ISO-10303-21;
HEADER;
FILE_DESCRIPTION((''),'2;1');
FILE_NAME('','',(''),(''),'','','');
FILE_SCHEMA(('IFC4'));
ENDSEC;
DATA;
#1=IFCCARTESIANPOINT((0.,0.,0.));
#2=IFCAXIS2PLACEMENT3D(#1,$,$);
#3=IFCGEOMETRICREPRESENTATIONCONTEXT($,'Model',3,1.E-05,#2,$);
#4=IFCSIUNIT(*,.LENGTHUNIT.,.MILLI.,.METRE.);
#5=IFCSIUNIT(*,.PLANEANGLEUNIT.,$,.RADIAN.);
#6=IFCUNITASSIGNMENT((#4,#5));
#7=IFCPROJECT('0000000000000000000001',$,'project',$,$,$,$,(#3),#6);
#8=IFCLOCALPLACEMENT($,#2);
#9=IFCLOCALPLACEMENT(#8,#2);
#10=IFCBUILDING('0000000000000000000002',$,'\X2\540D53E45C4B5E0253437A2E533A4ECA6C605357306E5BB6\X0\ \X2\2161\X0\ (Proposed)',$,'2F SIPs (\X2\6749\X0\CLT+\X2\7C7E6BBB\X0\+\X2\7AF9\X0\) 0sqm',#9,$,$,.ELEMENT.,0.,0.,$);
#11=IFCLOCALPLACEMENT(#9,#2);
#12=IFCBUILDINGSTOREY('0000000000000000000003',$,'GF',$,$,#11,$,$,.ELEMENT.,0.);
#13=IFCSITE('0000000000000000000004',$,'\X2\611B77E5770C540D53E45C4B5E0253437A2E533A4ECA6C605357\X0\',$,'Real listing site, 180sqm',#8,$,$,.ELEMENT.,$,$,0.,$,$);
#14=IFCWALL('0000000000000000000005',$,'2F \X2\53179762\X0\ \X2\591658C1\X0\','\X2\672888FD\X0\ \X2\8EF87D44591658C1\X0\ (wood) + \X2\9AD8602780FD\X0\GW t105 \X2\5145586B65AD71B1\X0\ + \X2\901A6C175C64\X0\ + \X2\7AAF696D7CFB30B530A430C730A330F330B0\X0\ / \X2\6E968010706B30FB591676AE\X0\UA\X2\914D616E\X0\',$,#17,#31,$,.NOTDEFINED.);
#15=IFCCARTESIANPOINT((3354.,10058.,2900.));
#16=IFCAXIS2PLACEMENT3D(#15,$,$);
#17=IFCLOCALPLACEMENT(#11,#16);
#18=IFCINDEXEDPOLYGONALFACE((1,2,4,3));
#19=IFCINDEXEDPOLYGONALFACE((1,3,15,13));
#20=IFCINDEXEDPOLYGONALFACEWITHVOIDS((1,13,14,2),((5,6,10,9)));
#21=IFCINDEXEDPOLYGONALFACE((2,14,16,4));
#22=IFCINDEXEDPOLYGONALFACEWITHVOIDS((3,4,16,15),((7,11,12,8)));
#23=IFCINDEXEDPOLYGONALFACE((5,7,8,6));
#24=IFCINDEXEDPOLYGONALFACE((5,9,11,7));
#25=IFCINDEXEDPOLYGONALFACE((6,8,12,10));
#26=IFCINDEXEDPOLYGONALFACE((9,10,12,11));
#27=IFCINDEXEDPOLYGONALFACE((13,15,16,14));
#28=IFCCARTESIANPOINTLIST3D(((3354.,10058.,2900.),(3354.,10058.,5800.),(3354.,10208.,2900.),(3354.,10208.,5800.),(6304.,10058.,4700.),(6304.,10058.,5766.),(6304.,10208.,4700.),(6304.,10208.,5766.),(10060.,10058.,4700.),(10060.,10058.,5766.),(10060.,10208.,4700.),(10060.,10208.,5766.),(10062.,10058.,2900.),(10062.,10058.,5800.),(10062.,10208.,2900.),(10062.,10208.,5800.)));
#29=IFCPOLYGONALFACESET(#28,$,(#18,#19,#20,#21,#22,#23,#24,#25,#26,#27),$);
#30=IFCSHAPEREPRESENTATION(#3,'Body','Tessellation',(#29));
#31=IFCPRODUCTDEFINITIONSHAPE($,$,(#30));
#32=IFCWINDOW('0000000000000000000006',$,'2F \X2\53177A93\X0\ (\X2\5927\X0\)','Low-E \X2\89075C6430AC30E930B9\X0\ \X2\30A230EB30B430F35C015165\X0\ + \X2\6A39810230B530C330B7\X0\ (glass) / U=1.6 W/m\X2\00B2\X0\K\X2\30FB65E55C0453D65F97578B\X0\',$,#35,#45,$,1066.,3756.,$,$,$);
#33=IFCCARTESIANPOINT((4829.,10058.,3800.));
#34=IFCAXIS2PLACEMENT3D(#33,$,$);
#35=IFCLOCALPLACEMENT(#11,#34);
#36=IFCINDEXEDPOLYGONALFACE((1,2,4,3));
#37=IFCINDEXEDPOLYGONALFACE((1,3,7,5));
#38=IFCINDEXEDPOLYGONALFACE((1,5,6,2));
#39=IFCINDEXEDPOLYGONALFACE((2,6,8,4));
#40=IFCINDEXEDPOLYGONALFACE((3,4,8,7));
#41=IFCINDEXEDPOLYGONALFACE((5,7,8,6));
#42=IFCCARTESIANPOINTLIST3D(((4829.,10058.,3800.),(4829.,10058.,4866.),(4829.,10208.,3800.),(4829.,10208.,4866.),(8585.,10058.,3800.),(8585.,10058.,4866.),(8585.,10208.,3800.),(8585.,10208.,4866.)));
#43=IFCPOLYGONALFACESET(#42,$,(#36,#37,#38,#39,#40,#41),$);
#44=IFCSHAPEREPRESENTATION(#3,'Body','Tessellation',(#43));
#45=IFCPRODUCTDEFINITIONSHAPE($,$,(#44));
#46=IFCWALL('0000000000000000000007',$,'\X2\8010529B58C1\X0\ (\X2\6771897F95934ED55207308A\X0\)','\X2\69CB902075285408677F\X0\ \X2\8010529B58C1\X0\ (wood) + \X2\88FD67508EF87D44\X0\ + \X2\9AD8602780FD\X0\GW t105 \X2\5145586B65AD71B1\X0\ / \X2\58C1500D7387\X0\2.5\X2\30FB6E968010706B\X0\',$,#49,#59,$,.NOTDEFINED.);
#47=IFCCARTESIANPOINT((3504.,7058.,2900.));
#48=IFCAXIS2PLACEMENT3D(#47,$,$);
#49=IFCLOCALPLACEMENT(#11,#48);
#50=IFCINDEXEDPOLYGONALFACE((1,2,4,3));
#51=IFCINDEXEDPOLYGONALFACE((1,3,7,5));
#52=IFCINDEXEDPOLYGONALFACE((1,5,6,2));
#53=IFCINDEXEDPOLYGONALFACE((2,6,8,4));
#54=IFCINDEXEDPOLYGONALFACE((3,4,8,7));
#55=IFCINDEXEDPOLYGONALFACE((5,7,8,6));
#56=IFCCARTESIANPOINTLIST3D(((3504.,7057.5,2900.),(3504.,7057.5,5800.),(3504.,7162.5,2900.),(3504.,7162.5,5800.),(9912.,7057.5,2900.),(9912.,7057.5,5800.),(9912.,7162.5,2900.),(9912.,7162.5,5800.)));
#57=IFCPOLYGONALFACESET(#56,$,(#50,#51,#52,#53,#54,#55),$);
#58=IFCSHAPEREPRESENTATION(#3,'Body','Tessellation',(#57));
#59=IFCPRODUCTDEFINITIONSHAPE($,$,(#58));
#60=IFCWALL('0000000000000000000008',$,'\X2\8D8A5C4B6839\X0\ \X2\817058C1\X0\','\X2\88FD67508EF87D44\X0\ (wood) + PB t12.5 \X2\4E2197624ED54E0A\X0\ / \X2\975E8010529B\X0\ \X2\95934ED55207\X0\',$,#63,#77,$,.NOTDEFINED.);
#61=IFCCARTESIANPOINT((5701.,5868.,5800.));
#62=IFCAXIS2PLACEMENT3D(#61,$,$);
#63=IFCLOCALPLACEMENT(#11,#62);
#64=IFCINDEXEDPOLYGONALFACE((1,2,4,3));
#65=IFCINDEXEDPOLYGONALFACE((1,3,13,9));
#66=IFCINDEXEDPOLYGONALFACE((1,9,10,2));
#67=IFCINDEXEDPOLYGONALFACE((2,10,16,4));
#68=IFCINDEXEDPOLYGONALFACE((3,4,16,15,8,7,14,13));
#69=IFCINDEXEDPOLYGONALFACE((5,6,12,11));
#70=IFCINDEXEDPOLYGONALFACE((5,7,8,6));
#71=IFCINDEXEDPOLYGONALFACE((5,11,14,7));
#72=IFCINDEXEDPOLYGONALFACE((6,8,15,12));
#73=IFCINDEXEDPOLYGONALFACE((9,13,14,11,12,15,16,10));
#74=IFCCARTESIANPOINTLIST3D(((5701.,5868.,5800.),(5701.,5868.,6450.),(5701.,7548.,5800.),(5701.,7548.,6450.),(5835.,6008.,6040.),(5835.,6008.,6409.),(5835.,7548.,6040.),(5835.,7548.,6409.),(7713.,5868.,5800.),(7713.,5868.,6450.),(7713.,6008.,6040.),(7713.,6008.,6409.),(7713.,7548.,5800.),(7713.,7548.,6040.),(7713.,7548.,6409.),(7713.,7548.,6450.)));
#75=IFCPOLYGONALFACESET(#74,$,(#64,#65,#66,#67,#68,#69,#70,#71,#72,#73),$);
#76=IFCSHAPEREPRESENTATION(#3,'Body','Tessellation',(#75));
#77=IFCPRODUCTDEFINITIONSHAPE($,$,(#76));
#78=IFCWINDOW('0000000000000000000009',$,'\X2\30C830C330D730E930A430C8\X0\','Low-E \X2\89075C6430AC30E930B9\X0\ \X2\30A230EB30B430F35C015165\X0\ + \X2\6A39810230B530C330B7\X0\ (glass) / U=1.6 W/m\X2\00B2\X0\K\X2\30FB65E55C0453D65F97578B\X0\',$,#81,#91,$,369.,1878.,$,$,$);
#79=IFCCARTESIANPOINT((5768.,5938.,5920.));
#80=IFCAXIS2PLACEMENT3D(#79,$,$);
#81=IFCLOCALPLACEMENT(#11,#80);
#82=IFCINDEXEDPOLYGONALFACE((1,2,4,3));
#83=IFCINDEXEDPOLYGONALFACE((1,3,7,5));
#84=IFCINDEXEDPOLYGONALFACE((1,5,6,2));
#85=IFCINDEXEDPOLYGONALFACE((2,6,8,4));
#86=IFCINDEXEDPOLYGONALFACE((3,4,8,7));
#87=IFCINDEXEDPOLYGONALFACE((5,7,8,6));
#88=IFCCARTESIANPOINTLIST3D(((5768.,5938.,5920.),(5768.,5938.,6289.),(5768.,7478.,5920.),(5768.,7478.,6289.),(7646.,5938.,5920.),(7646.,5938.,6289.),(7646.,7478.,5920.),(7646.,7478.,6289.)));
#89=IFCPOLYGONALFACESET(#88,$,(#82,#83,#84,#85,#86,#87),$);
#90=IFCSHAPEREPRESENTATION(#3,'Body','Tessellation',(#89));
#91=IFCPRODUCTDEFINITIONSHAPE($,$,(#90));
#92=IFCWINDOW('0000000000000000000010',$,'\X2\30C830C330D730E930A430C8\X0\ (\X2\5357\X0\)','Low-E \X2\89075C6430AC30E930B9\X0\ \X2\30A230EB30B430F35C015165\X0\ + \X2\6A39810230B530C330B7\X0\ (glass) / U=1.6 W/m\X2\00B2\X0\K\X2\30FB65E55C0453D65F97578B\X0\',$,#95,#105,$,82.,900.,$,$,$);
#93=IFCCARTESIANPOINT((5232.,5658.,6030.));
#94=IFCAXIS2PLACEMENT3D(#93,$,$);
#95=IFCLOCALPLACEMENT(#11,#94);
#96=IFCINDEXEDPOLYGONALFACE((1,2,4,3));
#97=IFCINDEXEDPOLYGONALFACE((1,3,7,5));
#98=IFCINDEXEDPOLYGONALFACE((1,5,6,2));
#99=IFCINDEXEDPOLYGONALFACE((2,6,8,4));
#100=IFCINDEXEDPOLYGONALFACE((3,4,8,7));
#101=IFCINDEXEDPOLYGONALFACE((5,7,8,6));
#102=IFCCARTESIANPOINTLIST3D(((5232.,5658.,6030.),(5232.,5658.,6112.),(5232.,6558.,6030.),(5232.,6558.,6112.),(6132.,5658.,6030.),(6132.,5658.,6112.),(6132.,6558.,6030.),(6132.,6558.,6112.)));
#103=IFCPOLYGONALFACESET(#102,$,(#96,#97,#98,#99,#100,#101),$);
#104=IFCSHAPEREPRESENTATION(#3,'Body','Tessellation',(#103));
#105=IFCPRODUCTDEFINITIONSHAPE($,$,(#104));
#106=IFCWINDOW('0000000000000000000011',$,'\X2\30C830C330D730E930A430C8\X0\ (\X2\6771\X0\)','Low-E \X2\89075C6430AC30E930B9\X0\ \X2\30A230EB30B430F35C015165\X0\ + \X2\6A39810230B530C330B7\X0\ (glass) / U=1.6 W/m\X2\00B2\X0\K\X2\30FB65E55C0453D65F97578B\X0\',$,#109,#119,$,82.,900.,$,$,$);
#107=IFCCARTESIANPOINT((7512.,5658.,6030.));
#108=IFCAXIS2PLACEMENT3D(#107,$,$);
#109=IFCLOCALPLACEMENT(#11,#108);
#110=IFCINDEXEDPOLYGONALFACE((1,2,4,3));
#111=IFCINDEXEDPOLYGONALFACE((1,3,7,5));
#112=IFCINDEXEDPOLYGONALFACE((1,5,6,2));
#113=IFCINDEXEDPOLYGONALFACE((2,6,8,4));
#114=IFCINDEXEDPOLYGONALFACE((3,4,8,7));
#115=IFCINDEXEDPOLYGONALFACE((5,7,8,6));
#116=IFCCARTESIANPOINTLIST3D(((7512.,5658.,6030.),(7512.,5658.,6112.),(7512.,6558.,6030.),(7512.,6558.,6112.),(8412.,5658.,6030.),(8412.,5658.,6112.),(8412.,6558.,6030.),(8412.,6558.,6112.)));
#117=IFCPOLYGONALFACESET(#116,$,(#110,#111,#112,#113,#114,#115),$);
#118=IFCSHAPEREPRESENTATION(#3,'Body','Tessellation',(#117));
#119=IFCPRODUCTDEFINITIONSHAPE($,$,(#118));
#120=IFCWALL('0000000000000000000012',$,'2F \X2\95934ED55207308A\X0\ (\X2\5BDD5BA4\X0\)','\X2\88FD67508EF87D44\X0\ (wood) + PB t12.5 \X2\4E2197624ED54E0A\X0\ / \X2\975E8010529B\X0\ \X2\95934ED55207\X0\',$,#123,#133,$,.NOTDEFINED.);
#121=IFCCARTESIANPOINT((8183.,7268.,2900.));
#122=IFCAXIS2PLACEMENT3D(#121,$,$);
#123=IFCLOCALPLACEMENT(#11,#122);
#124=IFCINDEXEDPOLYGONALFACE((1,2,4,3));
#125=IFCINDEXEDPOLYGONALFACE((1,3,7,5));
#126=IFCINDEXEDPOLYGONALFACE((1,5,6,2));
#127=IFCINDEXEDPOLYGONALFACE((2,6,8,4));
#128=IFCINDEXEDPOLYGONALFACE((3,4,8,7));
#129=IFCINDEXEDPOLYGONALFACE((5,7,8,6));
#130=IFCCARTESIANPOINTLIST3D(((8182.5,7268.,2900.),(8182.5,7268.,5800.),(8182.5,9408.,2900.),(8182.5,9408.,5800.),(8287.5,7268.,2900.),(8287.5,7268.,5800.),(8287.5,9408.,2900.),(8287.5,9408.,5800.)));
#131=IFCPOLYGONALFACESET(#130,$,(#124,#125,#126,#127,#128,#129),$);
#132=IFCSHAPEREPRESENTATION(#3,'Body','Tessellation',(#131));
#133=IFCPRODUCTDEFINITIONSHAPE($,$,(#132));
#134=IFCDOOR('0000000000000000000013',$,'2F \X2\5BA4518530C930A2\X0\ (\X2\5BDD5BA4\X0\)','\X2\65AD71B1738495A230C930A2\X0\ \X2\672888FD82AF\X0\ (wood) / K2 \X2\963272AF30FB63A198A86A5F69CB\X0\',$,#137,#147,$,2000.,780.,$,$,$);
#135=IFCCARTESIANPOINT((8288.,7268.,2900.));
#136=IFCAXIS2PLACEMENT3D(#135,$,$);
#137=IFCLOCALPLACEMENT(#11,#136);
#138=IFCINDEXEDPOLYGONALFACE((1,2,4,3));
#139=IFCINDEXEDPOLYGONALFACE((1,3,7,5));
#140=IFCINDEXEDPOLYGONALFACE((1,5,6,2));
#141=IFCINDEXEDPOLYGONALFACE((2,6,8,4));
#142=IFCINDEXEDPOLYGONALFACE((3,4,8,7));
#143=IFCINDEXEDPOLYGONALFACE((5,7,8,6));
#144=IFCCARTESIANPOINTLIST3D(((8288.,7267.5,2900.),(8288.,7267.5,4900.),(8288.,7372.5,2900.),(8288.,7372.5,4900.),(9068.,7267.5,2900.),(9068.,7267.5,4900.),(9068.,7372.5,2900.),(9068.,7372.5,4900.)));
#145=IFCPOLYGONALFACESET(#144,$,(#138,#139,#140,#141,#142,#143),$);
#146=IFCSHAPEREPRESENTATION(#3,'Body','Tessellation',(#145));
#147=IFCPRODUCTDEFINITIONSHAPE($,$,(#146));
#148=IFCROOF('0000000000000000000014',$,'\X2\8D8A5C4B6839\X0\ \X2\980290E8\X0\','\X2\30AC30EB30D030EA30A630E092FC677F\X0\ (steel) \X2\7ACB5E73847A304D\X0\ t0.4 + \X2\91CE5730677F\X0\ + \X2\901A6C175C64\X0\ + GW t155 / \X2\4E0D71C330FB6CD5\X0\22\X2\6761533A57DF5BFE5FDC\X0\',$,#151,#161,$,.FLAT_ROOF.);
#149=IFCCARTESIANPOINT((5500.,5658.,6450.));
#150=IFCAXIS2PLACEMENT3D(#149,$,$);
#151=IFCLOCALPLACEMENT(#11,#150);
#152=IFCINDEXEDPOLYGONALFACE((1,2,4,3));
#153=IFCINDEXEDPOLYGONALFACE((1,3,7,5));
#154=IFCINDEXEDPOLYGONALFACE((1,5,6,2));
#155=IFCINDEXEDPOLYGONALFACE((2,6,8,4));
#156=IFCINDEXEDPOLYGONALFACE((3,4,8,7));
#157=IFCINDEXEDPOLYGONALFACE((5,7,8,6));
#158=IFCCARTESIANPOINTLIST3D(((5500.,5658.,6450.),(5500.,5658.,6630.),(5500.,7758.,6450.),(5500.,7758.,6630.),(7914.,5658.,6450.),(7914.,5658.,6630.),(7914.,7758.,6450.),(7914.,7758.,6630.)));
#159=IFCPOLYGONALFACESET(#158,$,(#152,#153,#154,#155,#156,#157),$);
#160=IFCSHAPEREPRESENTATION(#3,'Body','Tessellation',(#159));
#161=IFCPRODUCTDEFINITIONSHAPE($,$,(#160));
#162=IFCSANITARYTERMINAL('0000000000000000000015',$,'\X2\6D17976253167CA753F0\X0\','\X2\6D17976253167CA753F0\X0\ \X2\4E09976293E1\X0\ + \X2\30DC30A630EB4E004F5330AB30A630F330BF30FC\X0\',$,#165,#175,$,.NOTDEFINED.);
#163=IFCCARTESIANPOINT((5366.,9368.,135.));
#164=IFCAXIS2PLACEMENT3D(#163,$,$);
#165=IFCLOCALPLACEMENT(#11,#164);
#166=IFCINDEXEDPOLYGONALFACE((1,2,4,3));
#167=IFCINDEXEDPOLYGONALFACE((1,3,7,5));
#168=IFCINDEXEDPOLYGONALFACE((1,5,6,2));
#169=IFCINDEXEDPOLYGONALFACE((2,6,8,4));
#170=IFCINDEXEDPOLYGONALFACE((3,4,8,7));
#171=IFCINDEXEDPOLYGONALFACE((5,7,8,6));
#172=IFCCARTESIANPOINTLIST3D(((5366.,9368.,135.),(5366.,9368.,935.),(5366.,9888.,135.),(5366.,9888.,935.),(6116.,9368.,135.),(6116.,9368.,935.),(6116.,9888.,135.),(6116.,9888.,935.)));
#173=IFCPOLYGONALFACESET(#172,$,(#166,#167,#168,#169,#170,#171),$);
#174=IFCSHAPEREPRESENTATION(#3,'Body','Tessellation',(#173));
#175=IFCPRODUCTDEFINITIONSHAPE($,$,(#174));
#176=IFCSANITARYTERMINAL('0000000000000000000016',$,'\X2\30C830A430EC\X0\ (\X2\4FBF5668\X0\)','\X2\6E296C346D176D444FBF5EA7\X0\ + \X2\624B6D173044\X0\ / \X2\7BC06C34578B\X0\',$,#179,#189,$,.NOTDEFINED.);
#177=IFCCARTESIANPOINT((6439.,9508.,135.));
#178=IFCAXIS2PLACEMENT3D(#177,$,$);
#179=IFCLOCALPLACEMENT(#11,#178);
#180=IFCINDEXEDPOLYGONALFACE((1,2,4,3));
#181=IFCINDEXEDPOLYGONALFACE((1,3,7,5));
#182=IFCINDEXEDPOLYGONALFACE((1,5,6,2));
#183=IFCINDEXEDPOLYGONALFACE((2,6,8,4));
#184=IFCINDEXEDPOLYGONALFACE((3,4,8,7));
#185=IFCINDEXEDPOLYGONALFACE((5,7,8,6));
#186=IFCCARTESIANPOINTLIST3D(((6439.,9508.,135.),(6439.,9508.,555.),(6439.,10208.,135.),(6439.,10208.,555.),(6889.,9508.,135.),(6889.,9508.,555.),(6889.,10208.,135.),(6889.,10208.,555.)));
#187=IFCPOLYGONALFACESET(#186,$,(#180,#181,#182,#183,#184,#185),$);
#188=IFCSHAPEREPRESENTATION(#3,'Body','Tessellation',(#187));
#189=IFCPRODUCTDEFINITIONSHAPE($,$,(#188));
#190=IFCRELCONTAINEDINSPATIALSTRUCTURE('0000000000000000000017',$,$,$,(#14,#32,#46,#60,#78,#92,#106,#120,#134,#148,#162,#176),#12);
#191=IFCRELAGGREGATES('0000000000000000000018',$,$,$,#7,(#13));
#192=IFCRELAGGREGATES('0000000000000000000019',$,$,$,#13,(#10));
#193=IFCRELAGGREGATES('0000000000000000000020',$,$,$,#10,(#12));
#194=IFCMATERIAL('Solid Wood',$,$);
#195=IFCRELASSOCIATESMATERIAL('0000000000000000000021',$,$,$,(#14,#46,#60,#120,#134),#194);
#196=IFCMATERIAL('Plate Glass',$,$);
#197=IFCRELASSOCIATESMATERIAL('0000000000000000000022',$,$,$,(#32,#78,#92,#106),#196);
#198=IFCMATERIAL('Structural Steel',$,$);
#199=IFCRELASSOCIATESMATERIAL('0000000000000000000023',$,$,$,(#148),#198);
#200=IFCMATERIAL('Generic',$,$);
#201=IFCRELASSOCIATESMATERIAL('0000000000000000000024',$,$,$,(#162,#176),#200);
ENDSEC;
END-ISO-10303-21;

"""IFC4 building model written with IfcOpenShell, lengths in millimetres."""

from ifc_helpers import new_model, si_unit, frame, frame_2d, origin, place, context, project, spatial, rectangle, extrude, material, element, fill, save


model = new_model("IFC4")

# Units and contexts
model_context = context("Model", 3, precision=1e-05, world=origin())
ifc_project = project(units=[si_unit("LENGTHUNIT", "METRE", prefix="MILLI"), si_unit("PLANEANGLEUNIT", "RADIAN")], contexts=[model_context])

# Site, building, storey
site_placement = place(None, origin())
site = spatial("IfcSite", under=ifc_project, at=site_placement, Name="愛知県名古屋市千種区今池南", ObjectType="Real listing site, 180sqm", CompositionType="ELEMENT", RefElevation=0.0)
building_placement = place(site_placement, origin())
building = spatial("IfcBuilding", under=site, at=building_placement, Name="名古屋市千種区今池南の家 Ⅱ (Proposed)", ObjectType="2F SIPs (杉CLT+籾殻+竹) 0sqm", CompositionType="ELEMENT", ElevationOfRefHeight=0.0, ElevationOfTerrain=0.0)
storey_placement = place(building_placement, origin())
storey = spatial("IfcBuildingStorey", under=building, at=storey_placement, Name="GF", CompositionType="ELEMENT", Elevation=0.0)

# Wall, opening, window
ifc_material_1 = material(Name="Solid Wood")
wall_1_placement = place(storey_placement, frame((3354.0, 10058.0, 2900.0)))
wall_1 = element("IfcWall", 1, at=wall_1_placement, inside=storey, material=ifc_material_1, Name="2F 北面 外壁", Description="木製 軸組外壁 (wood) + 高性能GW t105 充填断熱 + 通気層 + 窯業系サイディング / 準耐火・外皮UA配慮", PredefinedType="NOTDEFINED", context=model_context, shape_type="SweptSolid", body=[
    extrude(rectangle(XDim=6708.0, YDim=150.0, at=frame_2d((3354.0, 75.0))), frame((3354.0, 10058.0, 2900.0)), (0.0, 0.0, 1.0), 2900.0),
])
opening_1_placement = place(storey_placement, frame((4829.0, 10058.0, 3800.0)))
opening_1 = element("IfcOpeningElement", 2, at=opening_1_placement, cuts=wall_1, PredefinedType="NOTDEFINED", context=model_context, shape_type="SweptSolid", body=[
    extrude(rectangle(XDim=3756.0, YDim=150.0, at=frame_2d((1878.0, 75.0))), frame((4829.0, 10058.0, 3800.0)), (0.0, 0.0, 1.0), 1066.0),
])
ifc_material_2 = material(Name="Plate Glass")
window_1_placement = place(storey_placement, frame((4829.0, 10058.0, 3800.0)))
window_1 = element("IfcWindow", 3, at=window_1_placement, inside=storey, material=ifc_material_2, Name="2F 北窓 (大)", Description="Low-E 複層ガラス アルゴン封入 + 樹脂サッシ (glass) / U=1.6 W/m²K・日射取得型", OverallHeight=1066.0, OverallWidth=3756.0, context=model_context, shape_type="SweptSolid", body=[
    extrude(rectangle(XDim=3756.0, YDim=150.0, at=frame_2d((1878.0, 75.0))), frame((4829.0, 10058.0, 3800.0)), (0.0, 0.0, 1.0), 1066.0),
])
fill(opening_1, window_1)

# Wall
wall_2_placement = place(storey_placement, frame((3504.0, 7058.0, 2900.0)))
element("IfcWall", 4, at=wall_2_placement, inside=storey, material=ifc_material_1, Name="耐力壁 (東西間仕切り)", Description="構造用合板 耐力壁 (wood) + 製材軸組 + 高性能GW t105 充填断熱 / 壁倍率2.5・準耐火", PredefinedType="NOTDEFINED", context=model_context, shape_type="SweptSolid", body=[
    extrude(rectangle(XDim=6408.0, YDim=105.0, at=frame_2d((3204.0, 52.0))), frame((3504.0, 7058.0, 2900.0)), (0.0, 0.0, 1.0), 2900.0),
])

# Wall, openings, windows
wall_3_placement = place(storey_placement, frame((5701.0, 5868.0, 5800.0)))
wall_3 = element("IfcWall", 5, at=wall_3_placement, inside=storey, material=ifc_material_1, Name="越屋根 腰壁", Description="製材軸組 (wood) + PB t12.5 両面仕上 / 非耐力 間仕切", PredefinedType="NOTDEFINED", context=model_context, shape_type="SweptSolid", body=[
    extrude(rectangle(XDim=2012.0, YDim=1680.0, at=frame_2d((1006.0, 840.0))), frame((5701.0, 5868.0, 5800.0)), (0.0, 0.0, 1.0), 650.0),
])
opening_2_placement = place(storey_placement, frame((5768.0, 5938.0, 5920.0)))
opening_2 = element("IfcOpeningElement", 6, at=opening_2_placement, cuts=wall_3, PredefinedType="NOTDEFINED", context=model_context, shape_type="SweptSolid", body=[
    extrude(rectangle(XDim=1878.0, YDim=1540.0, at=frame_2d((939.0, 770.0))), frame((5768.0, 5938.0, 5920.0)), (0.0, 0.0, 1.0), 369.0),
])
opening_3_placement = place(storey_placement, frame((5232.0, 5658.0, 6030.0)))
opening_3 = element("IfcOpeningElement", 7, at=opening_3_placement, cuts=wall_3, PredefinedType="NOTDEFINED", context=model_context, shape_type="SweptSolid", body=[
    extrude(rectangle(XDim=900.0, YDim=900.0, at=frame_2d((450.0, 450.0))), frame((5232.0, 5658.0, 6030.0)), (0.0, 0.0, 1.0), 82.0),
])
opening_4_placement = place(storey_placement, frame((7512.0, 5658.0, 6030.0)))
opening_4 = element("IfcOpeningElement", 8, at=opening_4_placement, cuts=wall_3, PredefinedType="NOTDEFINED", context=model_context, shape_type="SweptSolid", body=[
    extrude(rectangle(XDim=900.0, YDim=900.0, at=frame_2d((450.0, 450.0))), frame((7512.0, 5658.0, 6030.0)), (0.0, 0.0, 1.0), 82.0),
])
window_2_placement = place(storey_placement, frame((5768.0, 5938.0, 5920.0)))
window_2 = element("IfcWindow", 9, at=window_2_placement, inside=storey, material=ifc_material_2, Name="トップライト", Description="Low-E 複層ガラス アルゴン封入 + 樹脂サッシ (glass) / U=1.6 W/m²K・日射取得型", OverallHeight=369.0, OverallWidth=1878.0, context=model_context, shape_type="SweptSolid", body=[
    extrude(rectangle(XDim=1878.0, YDim=1540.0, at=frame_2d((939.0, 770.0))), frame((5768.0, 5938.0, 5920.0)), (0.0, 0.0, 1.0), 369.0),
])
fill(opening_2, window_2)
window_3_placement = place(storey_placement, frame((5232.0, 5658.0, 6030.0)))
window_3 = element("IfcWindow", 10, at=window_3_placement, inside=storey, material=ifc_material_2, Name="トップライト (南)", Description="Low-E 複層ガラス アルゴン封入 + 樹脂サッシ (glass) / U=1.6 W/m²K・日射取得型", OverallHeight=82.0, OverallWidth=900.0, context=model_context, shape_type="SweptSolid", body=[
    extrude(rectangle(XDim=900.0, YDim=900.0, at=frame_2d((450.0, 450.0))), frame((5232.0, 5658.0, 6030.0)), (0.0, 0.0, 1.0), 82.0),
])
fill(opening_3, window_3)
window_4_placement = place(storey_placement, frame((7512.0, 5658.0, 6030.0)))
window_4 = element("IfcWindow", 11, at=window_4_placement, inside=storey, material=ifc_material_2, Name="トップライト (東)", Description="Low-E 複層ガラス アルゴン封入 + 樹脂サッシ (glass) / U=1.6 W/m²K・日射取得型", OverallHeight=82.0, OverallWidth=900.0, context=model_context, shape_type="SweptSolid", body=[
    extrude(rectangle(XDim=900.0, YDim=900.0, at=frame_2d((450.0, 450.0))), frame((7512.0, 5658.0, 6030.0)), (0.0, 0.0, 1.0), 82.0),
])
fill(opening_4, window_4)

# Wall
wall_4_placement = place(storey_placement, frame((8183.0, 7268.0, 2900.0)))
element("IfcWall", 12, at=wall_4_placement, inside=storey, material=ifc_material_1, Name="2F 間仕切り (寝室)", Description="製材軸組 (wood) + PB t12.5 両面仕上 / 非耐力 間仕切", PredefinedType="NOTDEFINED", context=model_context, shape_type="SweptSolid", body=[
    extrude(rectangle(XDim=105.0, YDim=2140.0, at=frame_2d((52.0, 1070.0))), frame((8183.0, 7268.0, 2900.0)), (0.0, 0.0, 1.0), 2900.0),
])

# Door
door_placement = place(storey_placement, frame((8288.0, 7268.0, 2900.0)))
element("IfcDoor", 13, at=door_placement, inside=storey, material=ifc_material_1, Name="2F 室内ドア (寝室)", Description="断熱玄関ドア 木製芯 (wood) / K2 防犯・採風機構", OverallHeight=2000.0, OverallWidth=780.0, context=model_context, shape_type="SweptSolid", body=[
    extrude(rectangle(XDim=780.0, YDim=105.0, at=frame_2d((390.0, 52.0))), frame((8288.0, 7268.0, 2900.0)), (0.0, 0.0, 1.0), 2000.0),
])

# Roof
ifc_material_3 = material(Name="Structural Steel")
roof_placement = place(storey_placement, frame((5500.0, 5658.0, 6450.0)))
element("IfcRoof", 14, at=roof_placement, inside=storey, material=ifc_material_3, Name="越屋根 頂部", Description="ガルバリウム鋼板 (steel) 立平葺き t0.4 + 野地板 + 通気層 + GW t155 / 不燃・法22条区域対応", PredefinedType="FLAT_ROOF", context=model_context, shape_type="SweptSolid", body=[
    extrude(rectangle(XDim=2414.0, YDim=2100.0, at=frame_2d((1207.0, 1050.0))), frame((5500.0, 5658.0, 6450.0)), (0.0, 0.0, 1.0), 180.0),
])

# Sanitary terminals
ifc_material_4 = material(Name="Generic")
sanitary_terminal_1_placement = place(storey_placement, frame((5366.0, 9368.0, 135.0)))
element("IfcSanitaryTerminal", 15, at=sanitary_terminal_1_placement, inside=storey, material=ifc_material_4, Name="洗面化粧台", Description="洗面化粧台 三面鏡 + ボウル一体カウンター", PredefinedType="NOTDEFINED", context=model_context, shape_type="SweptSolid", body=[
    extrude(rectangle(XDim=750.0, YDim=520.0, at=frame_2d((375.0, 260.0))), frame((5366.0, 9368.0, 135.0)), (0.0, 0.0, 1.0), 800.0),
])
sanitary_terminal_2_placement = place(storey_placement, frame((6439.0, 9508.0, 135.0)))
element("IfcSanitaryTerminal", 16, at=sanitary_terminal_2_placement, inside=storey, material=ifc_material_4, Name="トイレ (便器)", Description="温水洗浄便座 + 手洗い / 節水型", PredefinedType="NOTDEFINED", context=model_context, shape_type="SweptSolid", body=[
    extrude(rectangle(XDim=450.0, YDim=700.0, at=frame_2d((225.0, 350.0))), frame((6439.0, 9508.0, 135.0)), (0.0, 0.0, 1.0), 420.0),
])

save(model, "model.ifc")
